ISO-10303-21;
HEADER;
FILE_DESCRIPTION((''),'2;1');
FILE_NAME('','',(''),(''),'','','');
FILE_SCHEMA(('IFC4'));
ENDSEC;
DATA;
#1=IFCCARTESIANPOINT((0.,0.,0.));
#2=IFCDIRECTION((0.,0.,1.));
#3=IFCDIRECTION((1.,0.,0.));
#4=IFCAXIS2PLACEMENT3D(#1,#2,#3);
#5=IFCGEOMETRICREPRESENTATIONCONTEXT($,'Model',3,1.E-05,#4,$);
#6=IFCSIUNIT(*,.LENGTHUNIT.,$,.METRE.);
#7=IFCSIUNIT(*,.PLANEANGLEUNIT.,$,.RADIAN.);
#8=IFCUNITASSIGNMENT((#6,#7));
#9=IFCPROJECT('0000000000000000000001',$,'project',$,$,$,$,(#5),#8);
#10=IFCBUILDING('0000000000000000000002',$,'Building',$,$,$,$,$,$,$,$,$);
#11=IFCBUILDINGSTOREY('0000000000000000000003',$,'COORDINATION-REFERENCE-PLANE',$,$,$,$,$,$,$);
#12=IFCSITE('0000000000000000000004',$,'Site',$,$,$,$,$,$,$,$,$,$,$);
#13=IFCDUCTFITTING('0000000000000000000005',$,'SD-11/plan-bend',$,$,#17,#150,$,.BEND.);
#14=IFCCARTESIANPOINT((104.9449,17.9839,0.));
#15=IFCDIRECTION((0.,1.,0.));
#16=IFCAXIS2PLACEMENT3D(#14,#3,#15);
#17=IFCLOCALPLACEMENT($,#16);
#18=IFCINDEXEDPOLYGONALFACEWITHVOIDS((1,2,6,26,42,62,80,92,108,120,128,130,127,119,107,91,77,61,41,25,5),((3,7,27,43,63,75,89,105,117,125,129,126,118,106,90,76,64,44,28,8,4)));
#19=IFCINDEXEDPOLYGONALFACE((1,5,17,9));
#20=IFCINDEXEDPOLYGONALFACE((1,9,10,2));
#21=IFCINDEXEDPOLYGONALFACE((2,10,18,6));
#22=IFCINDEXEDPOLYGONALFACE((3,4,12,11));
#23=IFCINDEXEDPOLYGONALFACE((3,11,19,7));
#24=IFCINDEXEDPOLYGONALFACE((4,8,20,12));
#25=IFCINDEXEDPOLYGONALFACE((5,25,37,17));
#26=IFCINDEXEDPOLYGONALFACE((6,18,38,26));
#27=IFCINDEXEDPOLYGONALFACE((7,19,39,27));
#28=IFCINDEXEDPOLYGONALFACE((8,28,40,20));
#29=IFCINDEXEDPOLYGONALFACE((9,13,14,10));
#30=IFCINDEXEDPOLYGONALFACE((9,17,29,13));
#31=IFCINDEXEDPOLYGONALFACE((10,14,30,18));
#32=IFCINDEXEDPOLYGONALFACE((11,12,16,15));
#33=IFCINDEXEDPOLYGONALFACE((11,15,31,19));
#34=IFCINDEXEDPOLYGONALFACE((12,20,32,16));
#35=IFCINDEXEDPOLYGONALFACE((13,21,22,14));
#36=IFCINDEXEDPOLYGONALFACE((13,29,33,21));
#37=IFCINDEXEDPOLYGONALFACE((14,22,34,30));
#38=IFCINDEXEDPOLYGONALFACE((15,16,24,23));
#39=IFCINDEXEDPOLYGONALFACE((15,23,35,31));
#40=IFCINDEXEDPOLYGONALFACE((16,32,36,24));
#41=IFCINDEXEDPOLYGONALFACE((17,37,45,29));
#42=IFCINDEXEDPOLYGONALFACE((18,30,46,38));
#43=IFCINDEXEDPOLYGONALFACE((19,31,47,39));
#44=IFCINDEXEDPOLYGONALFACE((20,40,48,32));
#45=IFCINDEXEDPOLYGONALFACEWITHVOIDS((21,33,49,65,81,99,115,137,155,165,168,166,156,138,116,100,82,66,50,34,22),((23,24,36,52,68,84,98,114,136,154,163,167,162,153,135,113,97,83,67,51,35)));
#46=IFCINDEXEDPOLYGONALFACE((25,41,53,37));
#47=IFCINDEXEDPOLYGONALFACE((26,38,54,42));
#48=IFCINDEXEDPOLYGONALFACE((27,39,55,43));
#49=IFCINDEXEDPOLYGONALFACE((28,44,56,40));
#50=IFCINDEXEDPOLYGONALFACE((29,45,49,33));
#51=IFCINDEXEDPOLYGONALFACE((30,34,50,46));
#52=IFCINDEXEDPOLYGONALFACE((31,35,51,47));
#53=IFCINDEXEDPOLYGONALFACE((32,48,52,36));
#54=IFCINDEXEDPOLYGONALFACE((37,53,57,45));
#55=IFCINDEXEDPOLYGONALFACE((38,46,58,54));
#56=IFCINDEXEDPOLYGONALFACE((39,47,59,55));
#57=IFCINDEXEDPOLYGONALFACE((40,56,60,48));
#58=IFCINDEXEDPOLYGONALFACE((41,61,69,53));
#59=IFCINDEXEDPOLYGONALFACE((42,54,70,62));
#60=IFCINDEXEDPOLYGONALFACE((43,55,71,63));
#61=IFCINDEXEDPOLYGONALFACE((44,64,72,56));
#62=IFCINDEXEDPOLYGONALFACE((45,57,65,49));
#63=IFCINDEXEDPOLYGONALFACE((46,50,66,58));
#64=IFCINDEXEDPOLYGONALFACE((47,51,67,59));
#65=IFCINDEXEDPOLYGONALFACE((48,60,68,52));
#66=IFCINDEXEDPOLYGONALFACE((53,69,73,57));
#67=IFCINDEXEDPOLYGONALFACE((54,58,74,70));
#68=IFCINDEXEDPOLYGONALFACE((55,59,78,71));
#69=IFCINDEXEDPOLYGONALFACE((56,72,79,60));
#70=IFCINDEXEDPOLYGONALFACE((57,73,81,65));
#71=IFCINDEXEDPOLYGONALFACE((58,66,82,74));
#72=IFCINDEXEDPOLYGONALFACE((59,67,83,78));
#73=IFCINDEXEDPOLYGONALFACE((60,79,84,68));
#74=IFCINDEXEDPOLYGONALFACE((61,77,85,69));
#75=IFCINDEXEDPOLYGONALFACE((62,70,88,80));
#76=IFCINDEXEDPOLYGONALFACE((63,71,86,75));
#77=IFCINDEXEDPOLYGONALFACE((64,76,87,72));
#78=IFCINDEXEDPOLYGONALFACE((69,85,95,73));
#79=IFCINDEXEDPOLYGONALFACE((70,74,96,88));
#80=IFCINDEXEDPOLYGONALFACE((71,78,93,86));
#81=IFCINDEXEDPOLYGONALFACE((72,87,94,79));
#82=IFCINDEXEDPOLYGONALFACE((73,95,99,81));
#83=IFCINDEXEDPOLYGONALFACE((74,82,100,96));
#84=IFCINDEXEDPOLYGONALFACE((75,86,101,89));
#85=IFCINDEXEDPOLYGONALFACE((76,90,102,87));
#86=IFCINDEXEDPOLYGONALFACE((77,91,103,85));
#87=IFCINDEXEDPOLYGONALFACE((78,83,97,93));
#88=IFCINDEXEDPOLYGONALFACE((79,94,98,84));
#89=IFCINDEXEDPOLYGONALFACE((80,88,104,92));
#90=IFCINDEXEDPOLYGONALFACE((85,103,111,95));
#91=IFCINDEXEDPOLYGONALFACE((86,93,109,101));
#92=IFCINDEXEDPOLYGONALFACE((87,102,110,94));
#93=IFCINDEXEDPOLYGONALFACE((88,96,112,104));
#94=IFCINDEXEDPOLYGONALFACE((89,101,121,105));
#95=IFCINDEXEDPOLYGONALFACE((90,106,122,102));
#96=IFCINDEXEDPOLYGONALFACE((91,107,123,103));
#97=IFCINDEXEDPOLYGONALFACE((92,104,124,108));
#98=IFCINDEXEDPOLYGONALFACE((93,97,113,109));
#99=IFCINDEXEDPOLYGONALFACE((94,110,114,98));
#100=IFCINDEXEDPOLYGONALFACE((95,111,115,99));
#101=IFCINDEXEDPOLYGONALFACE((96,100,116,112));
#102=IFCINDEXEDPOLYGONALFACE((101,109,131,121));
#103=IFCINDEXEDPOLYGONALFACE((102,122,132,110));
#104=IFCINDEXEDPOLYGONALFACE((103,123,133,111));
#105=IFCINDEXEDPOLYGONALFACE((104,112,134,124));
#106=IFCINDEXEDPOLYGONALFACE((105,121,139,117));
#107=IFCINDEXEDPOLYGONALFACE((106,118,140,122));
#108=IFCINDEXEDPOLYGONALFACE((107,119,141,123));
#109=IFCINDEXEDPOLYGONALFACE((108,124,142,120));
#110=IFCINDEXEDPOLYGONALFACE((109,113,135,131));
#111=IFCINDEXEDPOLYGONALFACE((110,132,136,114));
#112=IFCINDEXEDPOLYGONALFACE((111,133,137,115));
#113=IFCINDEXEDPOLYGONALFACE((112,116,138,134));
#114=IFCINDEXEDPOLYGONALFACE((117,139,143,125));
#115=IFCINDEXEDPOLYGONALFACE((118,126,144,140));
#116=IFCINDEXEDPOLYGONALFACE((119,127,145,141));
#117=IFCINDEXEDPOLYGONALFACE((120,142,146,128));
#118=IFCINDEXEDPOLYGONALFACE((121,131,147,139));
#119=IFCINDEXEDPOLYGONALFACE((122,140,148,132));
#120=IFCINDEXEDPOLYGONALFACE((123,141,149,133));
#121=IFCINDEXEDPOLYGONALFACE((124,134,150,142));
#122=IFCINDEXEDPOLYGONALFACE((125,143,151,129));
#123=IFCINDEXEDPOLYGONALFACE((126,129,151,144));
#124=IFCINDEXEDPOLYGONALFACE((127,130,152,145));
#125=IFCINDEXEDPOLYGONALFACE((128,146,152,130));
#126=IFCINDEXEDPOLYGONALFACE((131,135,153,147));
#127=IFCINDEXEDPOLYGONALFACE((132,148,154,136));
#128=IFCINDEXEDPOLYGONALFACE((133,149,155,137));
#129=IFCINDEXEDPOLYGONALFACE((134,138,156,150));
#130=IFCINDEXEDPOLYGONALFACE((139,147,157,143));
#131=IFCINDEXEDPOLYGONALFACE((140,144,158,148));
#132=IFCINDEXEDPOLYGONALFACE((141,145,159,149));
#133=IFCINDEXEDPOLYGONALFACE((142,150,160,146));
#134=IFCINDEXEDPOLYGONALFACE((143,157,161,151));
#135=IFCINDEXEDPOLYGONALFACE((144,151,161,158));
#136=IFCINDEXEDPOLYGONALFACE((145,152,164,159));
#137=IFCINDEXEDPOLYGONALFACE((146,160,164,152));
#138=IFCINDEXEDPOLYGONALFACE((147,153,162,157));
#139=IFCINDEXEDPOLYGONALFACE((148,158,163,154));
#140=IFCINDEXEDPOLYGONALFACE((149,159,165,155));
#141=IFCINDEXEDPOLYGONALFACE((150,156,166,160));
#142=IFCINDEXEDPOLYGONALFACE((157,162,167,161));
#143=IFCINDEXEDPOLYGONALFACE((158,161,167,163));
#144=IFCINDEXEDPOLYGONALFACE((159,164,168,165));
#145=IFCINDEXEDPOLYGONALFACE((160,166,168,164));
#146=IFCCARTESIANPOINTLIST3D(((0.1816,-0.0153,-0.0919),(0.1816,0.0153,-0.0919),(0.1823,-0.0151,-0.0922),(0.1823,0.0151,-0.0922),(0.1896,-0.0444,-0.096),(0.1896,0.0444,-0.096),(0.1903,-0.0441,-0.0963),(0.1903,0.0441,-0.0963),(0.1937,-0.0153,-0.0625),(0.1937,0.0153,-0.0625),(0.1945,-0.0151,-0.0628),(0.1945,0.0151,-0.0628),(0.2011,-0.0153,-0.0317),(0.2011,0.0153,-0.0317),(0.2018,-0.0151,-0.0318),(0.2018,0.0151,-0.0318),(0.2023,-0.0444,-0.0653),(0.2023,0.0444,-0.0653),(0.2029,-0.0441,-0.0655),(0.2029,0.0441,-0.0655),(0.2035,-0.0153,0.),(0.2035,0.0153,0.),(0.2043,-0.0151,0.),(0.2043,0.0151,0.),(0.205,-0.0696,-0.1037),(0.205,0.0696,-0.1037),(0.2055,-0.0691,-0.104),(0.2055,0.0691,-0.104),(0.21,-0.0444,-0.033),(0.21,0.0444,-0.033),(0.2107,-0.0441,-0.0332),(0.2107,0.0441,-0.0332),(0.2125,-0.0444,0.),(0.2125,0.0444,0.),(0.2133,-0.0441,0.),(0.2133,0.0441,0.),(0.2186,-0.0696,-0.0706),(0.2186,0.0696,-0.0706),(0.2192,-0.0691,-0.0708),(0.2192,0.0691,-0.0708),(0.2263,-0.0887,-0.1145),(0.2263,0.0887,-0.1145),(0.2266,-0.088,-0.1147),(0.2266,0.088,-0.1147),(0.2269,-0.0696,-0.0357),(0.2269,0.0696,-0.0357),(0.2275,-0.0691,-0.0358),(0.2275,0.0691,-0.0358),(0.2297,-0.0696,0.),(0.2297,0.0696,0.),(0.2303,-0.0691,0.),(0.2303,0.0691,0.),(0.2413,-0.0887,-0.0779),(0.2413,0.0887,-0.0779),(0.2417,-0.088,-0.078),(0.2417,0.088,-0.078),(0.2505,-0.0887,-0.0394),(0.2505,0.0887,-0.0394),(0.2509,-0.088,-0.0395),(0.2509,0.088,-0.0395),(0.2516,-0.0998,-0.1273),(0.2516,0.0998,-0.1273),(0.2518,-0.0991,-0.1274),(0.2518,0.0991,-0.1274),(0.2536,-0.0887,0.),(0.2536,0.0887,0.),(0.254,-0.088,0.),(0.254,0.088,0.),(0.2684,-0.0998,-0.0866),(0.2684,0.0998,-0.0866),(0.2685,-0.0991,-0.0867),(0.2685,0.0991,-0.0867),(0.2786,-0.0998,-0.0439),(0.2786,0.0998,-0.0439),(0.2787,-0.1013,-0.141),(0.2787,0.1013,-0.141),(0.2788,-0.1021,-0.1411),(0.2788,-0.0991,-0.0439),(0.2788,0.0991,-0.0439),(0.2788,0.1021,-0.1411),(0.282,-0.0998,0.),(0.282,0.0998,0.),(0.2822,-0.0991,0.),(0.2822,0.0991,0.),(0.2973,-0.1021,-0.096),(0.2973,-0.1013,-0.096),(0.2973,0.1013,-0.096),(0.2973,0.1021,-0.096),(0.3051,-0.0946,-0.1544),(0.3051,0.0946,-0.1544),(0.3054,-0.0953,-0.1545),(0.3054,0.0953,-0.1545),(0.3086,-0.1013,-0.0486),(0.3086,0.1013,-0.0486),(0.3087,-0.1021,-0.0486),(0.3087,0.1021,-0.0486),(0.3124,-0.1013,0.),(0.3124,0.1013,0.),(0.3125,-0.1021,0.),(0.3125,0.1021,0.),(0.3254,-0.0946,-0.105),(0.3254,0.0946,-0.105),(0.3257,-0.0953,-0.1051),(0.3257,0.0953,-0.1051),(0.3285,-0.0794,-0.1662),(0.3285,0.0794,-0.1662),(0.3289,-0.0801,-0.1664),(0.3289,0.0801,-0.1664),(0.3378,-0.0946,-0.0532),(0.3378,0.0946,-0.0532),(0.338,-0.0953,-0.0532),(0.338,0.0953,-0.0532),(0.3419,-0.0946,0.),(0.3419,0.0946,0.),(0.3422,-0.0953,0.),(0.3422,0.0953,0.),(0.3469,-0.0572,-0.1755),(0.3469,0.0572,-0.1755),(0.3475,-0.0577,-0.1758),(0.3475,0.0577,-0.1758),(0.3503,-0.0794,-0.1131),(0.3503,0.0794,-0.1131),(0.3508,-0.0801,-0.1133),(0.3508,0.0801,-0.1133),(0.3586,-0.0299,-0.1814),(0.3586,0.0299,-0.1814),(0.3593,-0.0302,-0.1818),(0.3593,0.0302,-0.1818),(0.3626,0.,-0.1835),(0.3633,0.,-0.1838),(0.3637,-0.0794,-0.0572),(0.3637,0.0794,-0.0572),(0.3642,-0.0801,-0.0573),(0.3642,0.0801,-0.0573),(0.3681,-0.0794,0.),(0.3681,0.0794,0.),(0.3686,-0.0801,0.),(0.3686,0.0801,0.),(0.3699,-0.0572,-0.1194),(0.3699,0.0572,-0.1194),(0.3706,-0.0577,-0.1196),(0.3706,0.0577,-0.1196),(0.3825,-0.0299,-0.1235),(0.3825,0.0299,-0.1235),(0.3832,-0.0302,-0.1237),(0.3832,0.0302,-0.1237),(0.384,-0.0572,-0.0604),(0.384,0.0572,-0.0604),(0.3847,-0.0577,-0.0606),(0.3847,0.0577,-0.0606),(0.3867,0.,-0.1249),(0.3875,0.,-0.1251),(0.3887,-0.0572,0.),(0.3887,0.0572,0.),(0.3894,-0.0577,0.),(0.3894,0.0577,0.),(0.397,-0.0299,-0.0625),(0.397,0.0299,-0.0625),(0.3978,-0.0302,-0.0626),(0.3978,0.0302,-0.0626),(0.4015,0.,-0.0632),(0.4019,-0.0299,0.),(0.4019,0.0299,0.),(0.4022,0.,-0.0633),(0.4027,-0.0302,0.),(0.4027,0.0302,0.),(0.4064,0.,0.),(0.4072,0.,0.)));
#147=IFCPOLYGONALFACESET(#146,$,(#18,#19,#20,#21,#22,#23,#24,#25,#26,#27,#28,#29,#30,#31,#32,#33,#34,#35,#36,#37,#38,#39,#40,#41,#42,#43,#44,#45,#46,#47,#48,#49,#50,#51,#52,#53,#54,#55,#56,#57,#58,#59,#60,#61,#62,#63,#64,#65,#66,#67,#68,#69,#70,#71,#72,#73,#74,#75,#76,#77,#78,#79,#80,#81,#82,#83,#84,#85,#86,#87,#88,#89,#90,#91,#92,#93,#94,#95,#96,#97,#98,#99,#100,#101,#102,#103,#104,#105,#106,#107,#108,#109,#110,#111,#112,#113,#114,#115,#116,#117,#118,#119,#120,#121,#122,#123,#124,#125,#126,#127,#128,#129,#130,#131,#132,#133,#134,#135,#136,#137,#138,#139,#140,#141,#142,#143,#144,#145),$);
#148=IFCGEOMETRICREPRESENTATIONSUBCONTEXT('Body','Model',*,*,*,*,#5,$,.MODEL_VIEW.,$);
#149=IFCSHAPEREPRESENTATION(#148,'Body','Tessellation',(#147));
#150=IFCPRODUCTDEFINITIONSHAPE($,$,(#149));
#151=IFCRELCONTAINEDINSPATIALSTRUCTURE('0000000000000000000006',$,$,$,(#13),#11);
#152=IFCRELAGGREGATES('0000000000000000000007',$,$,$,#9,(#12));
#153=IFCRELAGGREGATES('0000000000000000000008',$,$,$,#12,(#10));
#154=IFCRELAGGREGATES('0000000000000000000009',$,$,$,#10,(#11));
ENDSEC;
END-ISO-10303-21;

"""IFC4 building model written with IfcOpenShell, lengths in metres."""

from ifc_helpers import new_model, entity, si_unit, frame, origin_with_axes, place, context, subcontext, project, spatial, element, save


model = new_model("IFC4")

# Units and contexts
model_context_1 = context("Model", 3, precision=1e-05, world=origin_with_axes())
body_context_1 = subcontext(model_context_1, "Body", "Model", "MODEL_VIEW")
ifc_project = project(units=[si_unit("LENGTHUNIT", "METRE"), si_unit("PLANEANGLEUNIT", "RADIAN")], contexts=[model_context_1])

# Site, building, storey
site = spatial("IfcSite", under=ifc_project, Name="Site")
building = spatial("IfcBuilding", under=site, Name="Building")
storey = spatial("IfcBuildingStorey", under=building, Name="COORDINATION-REFERENCE-PLANE")

# Duct fitting
duct_fitting_1_placement = place(None, frame((104.9449, 17.9839, 0.0), z_axis=(1.0, 0.0, 0.0), x_axis=(0.0, 1.0, 0.0)))
element("IfcDuctFitting", 1, at=duct_fitting_1_placement, inside=storey, Name="SD-11/plan-bend", PredefinedType="BEND", context=body_context_1, shape_type="SweptSolid", body=[
    entity("IfcRevolvedAreaSolid", entity("IfcCircleHollowProfileDef", "AREA", None, entity("IfcAxis2Placement2D", entity("IfcCartesianPoint", [0.3048, 0.0])), 0.1024, 0.0008), entity("IfcAxis2Placement3D", entity("IfcCartesianPoint", [0.0, 0.0, 0.0]), entity("IfcDirection", [0.0, 0.0, 1.0]), entity("IfcDirection", [1.0, 0.0, 0.0])), entity("IfcAxis1Placement", entity("IfcCartesianPoint", [0.0, 0.0, 0.0]), entity("IfcDirection", [0.0, 1.0, 0.0])), 0.468399),
])

save(model, "model.ifc")
